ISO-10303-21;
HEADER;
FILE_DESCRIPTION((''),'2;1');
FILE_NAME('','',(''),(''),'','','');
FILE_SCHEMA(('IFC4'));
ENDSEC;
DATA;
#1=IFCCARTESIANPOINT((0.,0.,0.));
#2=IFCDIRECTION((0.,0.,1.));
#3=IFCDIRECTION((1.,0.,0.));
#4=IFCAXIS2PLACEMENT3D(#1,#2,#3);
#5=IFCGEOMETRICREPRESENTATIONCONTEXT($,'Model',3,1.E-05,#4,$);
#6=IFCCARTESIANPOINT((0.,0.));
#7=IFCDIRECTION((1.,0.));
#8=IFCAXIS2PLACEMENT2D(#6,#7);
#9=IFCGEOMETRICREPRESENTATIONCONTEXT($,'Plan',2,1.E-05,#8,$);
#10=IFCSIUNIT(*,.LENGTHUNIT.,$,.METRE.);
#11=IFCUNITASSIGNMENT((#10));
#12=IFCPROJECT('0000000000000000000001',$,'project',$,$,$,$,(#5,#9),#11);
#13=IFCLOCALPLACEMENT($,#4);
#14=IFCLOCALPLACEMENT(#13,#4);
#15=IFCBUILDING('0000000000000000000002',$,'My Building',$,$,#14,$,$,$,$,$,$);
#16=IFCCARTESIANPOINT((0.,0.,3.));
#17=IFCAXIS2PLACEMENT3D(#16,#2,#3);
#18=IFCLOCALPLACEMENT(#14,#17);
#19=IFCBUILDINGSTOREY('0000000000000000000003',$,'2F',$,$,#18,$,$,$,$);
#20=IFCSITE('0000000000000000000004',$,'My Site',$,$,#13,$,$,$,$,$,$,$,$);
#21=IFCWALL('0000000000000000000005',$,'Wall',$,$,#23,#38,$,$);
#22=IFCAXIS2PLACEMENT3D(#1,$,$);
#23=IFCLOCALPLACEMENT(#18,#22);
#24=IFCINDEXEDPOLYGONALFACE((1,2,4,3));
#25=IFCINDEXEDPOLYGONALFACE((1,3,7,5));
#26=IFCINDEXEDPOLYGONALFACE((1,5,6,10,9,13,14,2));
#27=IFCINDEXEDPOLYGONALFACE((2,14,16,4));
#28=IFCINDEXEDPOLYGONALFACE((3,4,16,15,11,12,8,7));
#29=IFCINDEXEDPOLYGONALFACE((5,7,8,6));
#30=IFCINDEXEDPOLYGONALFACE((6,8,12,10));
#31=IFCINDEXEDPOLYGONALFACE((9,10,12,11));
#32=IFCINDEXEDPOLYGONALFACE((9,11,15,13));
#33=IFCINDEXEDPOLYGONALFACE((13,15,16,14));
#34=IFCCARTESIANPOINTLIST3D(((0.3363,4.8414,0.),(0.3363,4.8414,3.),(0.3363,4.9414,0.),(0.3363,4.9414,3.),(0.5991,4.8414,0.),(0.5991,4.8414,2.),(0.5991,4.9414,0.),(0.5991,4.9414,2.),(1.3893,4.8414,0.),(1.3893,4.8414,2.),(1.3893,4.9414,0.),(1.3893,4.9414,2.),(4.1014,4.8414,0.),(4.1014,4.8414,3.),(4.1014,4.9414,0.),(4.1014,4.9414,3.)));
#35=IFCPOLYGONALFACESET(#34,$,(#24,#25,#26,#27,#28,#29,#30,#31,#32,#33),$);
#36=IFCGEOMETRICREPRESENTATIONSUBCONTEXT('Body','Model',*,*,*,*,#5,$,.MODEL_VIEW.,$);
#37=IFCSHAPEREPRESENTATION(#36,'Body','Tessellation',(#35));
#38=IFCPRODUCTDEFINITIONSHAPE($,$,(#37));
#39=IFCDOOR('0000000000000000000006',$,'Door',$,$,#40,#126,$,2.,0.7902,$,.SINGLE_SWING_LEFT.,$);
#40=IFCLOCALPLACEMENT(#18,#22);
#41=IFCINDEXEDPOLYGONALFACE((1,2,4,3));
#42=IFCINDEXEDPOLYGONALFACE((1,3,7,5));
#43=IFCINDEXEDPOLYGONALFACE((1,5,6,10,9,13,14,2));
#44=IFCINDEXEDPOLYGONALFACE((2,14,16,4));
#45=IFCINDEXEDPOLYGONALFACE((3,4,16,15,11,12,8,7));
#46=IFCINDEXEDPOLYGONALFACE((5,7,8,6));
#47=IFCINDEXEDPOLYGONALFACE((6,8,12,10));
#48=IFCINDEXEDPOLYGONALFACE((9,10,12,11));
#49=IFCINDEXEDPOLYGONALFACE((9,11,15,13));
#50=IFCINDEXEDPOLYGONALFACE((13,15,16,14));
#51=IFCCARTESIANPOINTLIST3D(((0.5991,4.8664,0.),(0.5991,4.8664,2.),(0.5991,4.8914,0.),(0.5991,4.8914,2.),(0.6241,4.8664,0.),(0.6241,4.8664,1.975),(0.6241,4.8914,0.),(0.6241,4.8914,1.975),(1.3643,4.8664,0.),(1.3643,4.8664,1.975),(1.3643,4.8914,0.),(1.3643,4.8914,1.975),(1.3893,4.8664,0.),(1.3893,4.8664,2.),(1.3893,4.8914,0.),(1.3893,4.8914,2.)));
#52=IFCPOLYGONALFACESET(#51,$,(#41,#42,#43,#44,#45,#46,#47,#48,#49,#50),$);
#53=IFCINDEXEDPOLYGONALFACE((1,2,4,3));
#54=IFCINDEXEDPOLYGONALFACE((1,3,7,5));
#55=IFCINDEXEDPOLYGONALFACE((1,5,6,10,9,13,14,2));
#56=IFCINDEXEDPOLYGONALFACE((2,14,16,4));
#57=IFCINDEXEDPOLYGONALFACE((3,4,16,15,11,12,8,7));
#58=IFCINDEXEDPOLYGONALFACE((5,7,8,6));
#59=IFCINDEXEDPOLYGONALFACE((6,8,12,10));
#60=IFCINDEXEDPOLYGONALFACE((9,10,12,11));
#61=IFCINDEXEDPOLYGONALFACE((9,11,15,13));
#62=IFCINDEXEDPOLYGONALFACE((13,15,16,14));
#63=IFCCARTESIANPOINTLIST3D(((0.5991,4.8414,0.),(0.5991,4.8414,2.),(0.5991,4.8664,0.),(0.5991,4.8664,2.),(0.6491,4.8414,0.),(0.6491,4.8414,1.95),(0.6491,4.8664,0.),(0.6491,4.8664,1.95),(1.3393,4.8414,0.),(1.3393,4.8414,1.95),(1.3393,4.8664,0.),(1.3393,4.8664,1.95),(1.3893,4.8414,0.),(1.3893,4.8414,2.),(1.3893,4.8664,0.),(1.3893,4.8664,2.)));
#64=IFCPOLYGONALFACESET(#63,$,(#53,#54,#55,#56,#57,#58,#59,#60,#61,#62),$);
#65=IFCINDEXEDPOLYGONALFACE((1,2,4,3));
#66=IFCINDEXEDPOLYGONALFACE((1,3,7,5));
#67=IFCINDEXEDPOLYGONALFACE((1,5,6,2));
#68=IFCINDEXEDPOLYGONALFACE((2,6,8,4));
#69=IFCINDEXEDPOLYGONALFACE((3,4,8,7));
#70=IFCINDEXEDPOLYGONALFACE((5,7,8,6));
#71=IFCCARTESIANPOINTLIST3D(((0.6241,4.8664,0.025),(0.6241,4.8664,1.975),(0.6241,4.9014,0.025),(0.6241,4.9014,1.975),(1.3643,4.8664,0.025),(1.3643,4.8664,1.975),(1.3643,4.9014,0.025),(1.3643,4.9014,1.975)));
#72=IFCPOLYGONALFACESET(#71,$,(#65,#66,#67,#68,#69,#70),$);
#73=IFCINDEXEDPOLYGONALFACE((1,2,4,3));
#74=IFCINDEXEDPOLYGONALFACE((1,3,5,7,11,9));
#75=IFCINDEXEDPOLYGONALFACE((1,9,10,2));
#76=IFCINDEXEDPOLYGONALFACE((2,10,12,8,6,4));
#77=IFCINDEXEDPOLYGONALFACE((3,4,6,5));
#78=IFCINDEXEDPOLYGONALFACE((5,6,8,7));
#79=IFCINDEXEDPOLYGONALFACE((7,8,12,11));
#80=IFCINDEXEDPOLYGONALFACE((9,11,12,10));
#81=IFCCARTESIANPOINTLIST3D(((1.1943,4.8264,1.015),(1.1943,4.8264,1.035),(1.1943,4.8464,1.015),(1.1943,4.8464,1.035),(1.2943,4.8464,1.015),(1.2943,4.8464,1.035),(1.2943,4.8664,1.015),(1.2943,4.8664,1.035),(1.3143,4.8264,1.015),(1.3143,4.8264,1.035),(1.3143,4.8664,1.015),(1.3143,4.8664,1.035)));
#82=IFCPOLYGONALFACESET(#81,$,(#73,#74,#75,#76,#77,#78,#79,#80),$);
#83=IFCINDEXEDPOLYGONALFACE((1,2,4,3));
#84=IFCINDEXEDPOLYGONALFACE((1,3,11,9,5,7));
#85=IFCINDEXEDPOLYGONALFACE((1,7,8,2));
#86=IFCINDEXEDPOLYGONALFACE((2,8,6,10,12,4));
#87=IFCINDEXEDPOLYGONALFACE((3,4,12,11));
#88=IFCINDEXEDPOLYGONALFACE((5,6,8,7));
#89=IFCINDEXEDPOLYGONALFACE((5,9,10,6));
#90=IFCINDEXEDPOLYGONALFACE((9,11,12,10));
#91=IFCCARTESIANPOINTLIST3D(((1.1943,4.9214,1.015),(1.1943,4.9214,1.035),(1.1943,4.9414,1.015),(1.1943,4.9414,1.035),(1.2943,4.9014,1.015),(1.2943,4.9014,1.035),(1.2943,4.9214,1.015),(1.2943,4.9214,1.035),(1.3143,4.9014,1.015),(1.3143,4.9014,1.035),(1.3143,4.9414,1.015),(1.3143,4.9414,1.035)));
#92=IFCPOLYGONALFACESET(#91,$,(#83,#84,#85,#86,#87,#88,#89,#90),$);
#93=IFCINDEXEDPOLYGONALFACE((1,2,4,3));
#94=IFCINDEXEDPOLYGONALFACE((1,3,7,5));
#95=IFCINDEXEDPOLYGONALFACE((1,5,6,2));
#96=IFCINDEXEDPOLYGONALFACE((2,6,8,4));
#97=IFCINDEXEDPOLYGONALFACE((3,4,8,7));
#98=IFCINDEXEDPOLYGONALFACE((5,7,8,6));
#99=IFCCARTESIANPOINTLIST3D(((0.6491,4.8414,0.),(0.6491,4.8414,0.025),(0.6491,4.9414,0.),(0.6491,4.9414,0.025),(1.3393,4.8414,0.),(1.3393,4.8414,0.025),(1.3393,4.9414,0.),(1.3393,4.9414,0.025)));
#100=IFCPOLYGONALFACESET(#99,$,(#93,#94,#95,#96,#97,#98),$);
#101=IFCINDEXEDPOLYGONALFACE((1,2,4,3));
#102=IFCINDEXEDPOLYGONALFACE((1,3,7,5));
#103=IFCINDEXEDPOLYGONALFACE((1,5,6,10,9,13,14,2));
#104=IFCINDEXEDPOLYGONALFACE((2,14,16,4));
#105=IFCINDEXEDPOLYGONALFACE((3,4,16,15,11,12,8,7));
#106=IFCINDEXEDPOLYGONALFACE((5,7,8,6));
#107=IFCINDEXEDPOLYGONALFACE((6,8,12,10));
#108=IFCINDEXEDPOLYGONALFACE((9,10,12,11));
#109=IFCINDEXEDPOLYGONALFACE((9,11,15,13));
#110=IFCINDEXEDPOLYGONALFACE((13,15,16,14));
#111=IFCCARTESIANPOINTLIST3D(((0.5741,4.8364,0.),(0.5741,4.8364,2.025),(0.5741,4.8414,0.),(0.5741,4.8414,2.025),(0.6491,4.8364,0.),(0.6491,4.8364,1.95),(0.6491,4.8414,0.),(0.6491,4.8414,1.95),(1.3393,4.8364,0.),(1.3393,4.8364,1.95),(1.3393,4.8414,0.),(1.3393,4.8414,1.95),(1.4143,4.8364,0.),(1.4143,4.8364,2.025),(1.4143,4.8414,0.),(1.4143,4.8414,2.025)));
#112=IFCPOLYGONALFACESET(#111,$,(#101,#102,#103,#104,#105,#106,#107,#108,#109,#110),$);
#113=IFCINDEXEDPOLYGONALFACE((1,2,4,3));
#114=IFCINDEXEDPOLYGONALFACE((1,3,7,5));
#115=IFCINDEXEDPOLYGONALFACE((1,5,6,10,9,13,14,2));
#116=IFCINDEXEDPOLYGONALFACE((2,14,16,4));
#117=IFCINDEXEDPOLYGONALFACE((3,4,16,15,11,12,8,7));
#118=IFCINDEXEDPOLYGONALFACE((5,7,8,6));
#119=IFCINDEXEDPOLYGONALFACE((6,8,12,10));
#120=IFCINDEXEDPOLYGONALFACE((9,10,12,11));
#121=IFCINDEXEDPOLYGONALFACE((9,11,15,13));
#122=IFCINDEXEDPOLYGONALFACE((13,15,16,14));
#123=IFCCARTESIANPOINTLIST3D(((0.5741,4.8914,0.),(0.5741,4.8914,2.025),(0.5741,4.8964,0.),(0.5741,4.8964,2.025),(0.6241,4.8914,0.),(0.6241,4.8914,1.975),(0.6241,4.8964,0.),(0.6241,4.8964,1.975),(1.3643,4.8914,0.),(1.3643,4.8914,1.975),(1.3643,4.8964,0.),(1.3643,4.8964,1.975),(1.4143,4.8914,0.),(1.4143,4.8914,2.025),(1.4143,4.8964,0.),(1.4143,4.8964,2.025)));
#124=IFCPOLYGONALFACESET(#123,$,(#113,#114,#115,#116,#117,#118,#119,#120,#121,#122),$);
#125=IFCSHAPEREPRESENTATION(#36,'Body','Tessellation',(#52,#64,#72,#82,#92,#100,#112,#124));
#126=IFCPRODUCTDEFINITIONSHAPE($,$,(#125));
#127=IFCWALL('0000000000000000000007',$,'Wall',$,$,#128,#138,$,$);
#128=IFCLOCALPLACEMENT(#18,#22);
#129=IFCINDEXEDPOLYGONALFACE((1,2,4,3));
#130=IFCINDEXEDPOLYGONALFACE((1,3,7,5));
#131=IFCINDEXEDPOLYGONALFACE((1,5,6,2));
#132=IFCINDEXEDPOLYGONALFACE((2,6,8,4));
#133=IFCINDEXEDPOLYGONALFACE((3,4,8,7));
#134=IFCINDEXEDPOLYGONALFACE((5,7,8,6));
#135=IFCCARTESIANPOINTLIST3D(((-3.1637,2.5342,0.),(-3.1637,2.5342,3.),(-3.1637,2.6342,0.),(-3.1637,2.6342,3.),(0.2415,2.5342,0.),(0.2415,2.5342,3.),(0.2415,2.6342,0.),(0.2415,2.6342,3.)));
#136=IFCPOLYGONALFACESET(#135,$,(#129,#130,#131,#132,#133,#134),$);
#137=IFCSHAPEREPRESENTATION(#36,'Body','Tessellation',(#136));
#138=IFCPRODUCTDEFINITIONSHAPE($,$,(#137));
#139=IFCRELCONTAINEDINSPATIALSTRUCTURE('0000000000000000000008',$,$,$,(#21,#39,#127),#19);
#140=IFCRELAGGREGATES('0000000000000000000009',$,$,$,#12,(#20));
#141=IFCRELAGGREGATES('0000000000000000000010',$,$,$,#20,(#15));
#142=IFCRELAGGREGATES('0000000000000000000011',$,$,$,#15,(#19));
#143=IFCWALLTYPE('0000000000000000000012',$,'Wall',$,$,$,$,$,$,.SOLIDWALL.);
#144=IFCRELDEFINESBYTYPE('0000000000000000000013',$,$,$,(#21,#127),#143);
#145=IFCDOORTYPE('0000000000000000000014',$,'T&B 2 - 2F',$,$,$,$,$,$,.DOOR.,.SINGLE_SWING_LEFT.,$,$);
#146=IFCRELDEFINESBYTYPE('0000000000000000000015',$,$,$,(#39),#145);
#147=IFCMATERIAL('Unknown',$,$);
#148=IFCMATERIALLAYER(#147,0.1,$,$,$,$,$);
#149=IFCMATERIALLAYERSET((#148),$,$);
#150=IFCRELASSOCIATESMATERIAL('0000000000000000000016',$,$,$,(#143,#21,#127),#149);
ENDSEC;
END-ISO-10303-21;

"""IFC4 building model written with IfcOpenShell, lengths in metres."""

from ifc_helpers import new_model, entity, si_unit, frame, origin_with_axes, origin_2d_with_axis, place, context, subcontext, project, spatial, line, indexed_curve, outline, extrude, shape, source, transform, mapped, material, layer, layer_set, layer_usage, type_object, type_shapes, element, fill, save


model = new_model("IFC4")

# Units and contexts
model_context = context("Model", 3, precision=1e-05, world=origin_with_axes())
plan_context = context("Plan", 2, precision=1e-05, world=origin_2d_with_axis())
body_context_1 = subcontext(model_context, "Body", "Model", "MODEL_VIEW")
body_context_2 = subcontext(plan_context, "Body", "Plan", "PLAN_VIEW")
ifc_project = project(units=[si_unit("LENGTHUNIT", "METRE")], contexts=[model_context, plan_context])

# Site, building, storey
site_placement = place(None, origin_with_axes())
site = spatial("IfcSite", under=ifc_project, at=site_placement, Name="My Site")
building_placement = place(site_placement, origin_with_axes())
building = spatial("IfcBuilding", under=site, at=building_placement, Name="My Building")
storey_placement = place(building_placement, frame((0.0, 0.0, 3.0), z_axis=(0.0, 0.0, 1.0), x_axis=(1.0, 0.0, 0.0)))
storey = spatial("IfcBuildingStorey", under=building, at=storey_placement, Name="2F")

# Shared definitions
ifc_material = material(Name="Unknown")

# Shared definitions
ifc_layer_1 = layer(ifc_material, 0.1)
ifc_layer_set_1 = layer_set([ifc_layer_1])
wall_type = type_object("IfcWallType", Name="Wall", PredefinedType="SOLIDWALL", material=ifc_layer_set_1)

# Wall, opening, door
ifc_layer_usage_1 = layer_usage(ifc_layer_set_1, "AXIS2", "POSITIVE", 0.0)
wall_1_placement = place(storey_placement, frame((0.3363, 4.8414, 0.0), z_axis=(0.0, 0.0, 1.0), x_axis=(1.0, 0.0, 0.0)))
wall_1 = element("IfcWall", 1, at=wall_1_placement, inside=storey, type_object=wall_type, material=ifc_layer_usage_1, Name="Wall", context=body_context_1, shape_type="SweptSolid", body=[
    extrude(outline(indexed_curve([(0.0, 0.0), (0.0, 0.1), (3.7651, 0.1), (3.7651, 0.0)], segments=[line(1, 2, 3, 4, 1)])), origin_with_axes(), (0.0, 0.0, 1.0), 3.0),
])
shared_shape_1 = source(origin_with_axes(), body_context_1, "Body", "SweptSolid", [
    extrude(outline(indexed_curve([(0.0, 0.0), (0.7902, 0.0), (0.7902, 2.0), (0.0, 2.0)], segments=[line(1, 2, 3, 4, 1)])), frame((0.0, -0.6, 0.0), z_axis=(0.0, -1.0, 0.0), x_axis=(1.0, 0.0, 0.0)), (0.0, 0.0, -1.0), 1.2),
])
opening_1_placement = place(wall_1_placement, frame((0.2628, 0.0, 0.0), z_axis=(0.0, 0.0, 1.0), x_axis=(1.0, 0.0, 0.0)))
opening_1 = element("IfcOpeningElement", 2, at=opening_1_placement, cuts=wall_1, PredefinedType="OPENING", context=body_context_1, shape_type="MappedRepresentation", body=[
    mapped(shared_shape_1, transform((0.0, 0.0, 0.0), x_axis=(1.0, 0.0, 0.0), y_axis=(0.0, 1.0, 0.0), z_axis=(0.0, 0.0, 1.0), scale=1.0)),
])
door_type_1 = type_object("IfcDoorType", Name="T&B 2 - 2F", OperationType="SINGLE_SWING_LEFT", PredefinedType="DOOR")
shared_shape_2 = source(origin_with_axes(), body_context_1, "Body", "SweptSolid", [
    extrude(outline(indexed_curve([(0.0, 0.0), (0.0, 2.0), (0.7902, 2.0), (0.7902, 0.0), (0.7652, 0.0), (0.7652, 1.975), (0.025, 1.975), (0.025, 0.0)], segments=[line(1, 2, 3, 4, 5, 6, 7, 8, 1)])), frame((0.0, 0.025, 0.0), z_axis=(0.0, -1.0, 0.0), x_axis=(1.0, 0.0, 0.0)), (0.0, 0.0, -1.0), 0.025),
    extrude(outline(indexed_curve([(0.0, 0.0), (0.0, 2.0), (0.7902, 2.0), (0.7902, 0.0), (0.7402, 0.0), (0.7402, 1.95), (0.05, 1.95), (0.05, 0.0)], segments=[line(1, 2, 3, 4, 5, 6, 7, 8, 1)])), frame((0.0, 0.0, 0.0), z_axis=(0.0, -1.0, 0.0), x_axis=(1.0, 0.0, 0.0)), (0.0, 0.0, -1.0), 0.025),
    extrude(outline(indexed_curve([(0.0, 0.0), (0.7402, 0.0), (0.7402, 0.035), (0.0, 0.035)], segments=[line(1, 2, 3, 4, 1)])), frame((0.025, 0.025, 0.025), z_axis=(0.0, 0.0, 1.0), x_axis=(1.0, 0.0, 0.0)), (0.0, 0.0, 1.0), 1.95),
    extrude(outline(indexed_curve([(0.0, 0.0), (0.0, -0.04), (-0.12, -0.04), (-0.12, -0.02), (-0.02, -0.02), (-0.02, 0.0)], segments=[line(1, 2, 3, 4, 5, 6, 1)])), frame((0.7152, 0.025, 1.015), z_axis=(0.0, 0.0, 1.0), x_axis=(1.0, 0.0, 0.0)), (0.0, 0.0, 1.0), 0.02),
    extrude(outline(indexed_curve([(0.0, 0.0), (0.0, 0.04), (-0.12, 0.04), (-0.12, 0.02), (-0.02, 0.02), (-0.02, 0.0)], segments=[line(1, 2, 3, 4, 5, 6, 1)])), frame((0.7152, 0.06, 1.015), z_axis=(0.0, 0.0, 1.0), x_axis=(1.0, 0.0, 0.0)), (0.0, 0.0, 1.0), 0.02),
    extrude(outline(indexed_curve([(0.0, 0.0), (0.6902, 0.0), (0.6902, 0.1), (0.0, 0.1)], segments=[line(1, 2, 3, 4, 1)])), frame((0.05, 0.0, 0.0), z_axis=(0.0, 0.0, 1.0), x_axis=(1.0, 0.0, 0.0)), (0.0, 0.0, 1.0), 0.025),
    extrude(outline(indexed_curve([(0.0, 0.0), (0.0, 2.025), (0.8402, 2.025), (0.8402, 0.0), (0.7652, 0.0), (0.7652, 1.95), (0.075, 1.95), (0.075, 0.0)], segments=[line(1, 2, 3, 4, 5, 6, 7, 8, 1)])), frame((-0.025, -0.005, 0.0), z_axis=(0.0, -1.0, 0.0), x_axis=(1.0, 0.0, 0.0)), (0.0, 0.0, -1.0), 0.005),
    extrude(outline(indexed_curve([(0.0, 0.0), (0.0, 2.025), (0.8402, 2.025), (0.8402, 0.0), (0.7902, 0.0), (0.7902, 1.975), (0.05, 1.975), (0.05, 0.0)], segments=[line(1, 2, 3, 4, 5, 6, 7, 8, 1)])), frame((-0.025, 0.05, 0.0), z_axis=(0.0, -1.0, 0.0), x_axis=(1.0, 0.0, 0.0)), (0.0, 0.0, -1.0), 0.005),
])
shared_shape_3 = source(origin_with_axes(), body_context_2, "Body", "Curve2D", [
    entity("IfcIndexedPolyCurve", entity("IfcCartesianPointList2D", [[0.0, 0.0], [0.0, 0.05], [0.025, 0.05], [0.025, 0.025], [0.05, 0.025], [0.05, 0.0]]), [entity("IfcLineIndex", [1, 2, 3, 4, 5, 6, 1])]),
    entity("IfcIndexedPolyCurve", entity("IfcCartesianPointList2D", [[0.7902, 0.0], [0.7902, 0.05], [0.7652, 0.05], [0.7652, 0.025], [0.7402, 0.025], [0.7402, 0.0]]), [entity("IfcLineIndex", [1, 2, 3, 4, 5, 6, 1])]),
    entity("IfcTrimmedCurve", entity("IfcEllipse", entity("IfcAxis2Placement2D", entity("IfcCartesianPoint", [0.06, 0.05]), entity("IfcDirection", [1.0, 0.0])), 0.7052, 0.7402), [entity("IfcCartesianPoint", [0.7652, 0.05])], [entity("IfcCartesianPoint", [0.06, 0.7902])], True, "CARTESIAN"),
    entity("IfcIndexedPolyCurve", entity("IfcCartesianPointList2D", [[0.025, 0.05], [0.06, 0.05], [0.06, 0.7902], [0.025, 0.7902]]), [entity("IfcLineIndex", [1, 2, 3, 4, 1])]),
])
type_shapes(door_type_1, [shared_shape_2, shared_shape_3])
door_1_placement = place(opening_1_placement, origin_with_axes())
door_1 = element("IfcDoor", 3, at=door_1_placement, inside=storey, type_object=door_type_1, Name="Door", OperationType="SINGLE_SWING_LEFT", OverallHeight=2.0, OverallWidth=0.7902, shapes=[
    shape(body_context_1, "Body", "MappedRepresentation", [mapped(shared_shape_2, transform((0.0, 0.0, 0.0), x_axis=(1.0, 0.0, 0.0), y_axis=(0.0, 1.0, 0.0), z_axis=(0.0, 0.0, 1.0), scale=1.0))]),
    shape(body_context_2, "Body", "MappedRepresentation", [mapped(shared_shape_3, transform((0.0, 0.0, 0.0), x_axis=(1.0, 0.0, 0.0), y_axis=(0.0, 1.0, 0.0), z_axis=(0.0, 0.0, 1.0), scale=1.0))]),
])
fill(opening_1, door_1)

# Wall
ifc_layer_usage_2 = layer_usage(ifc_layer_set_1, "AXIS2", "POSITIVE", 0.0)
wall_2_placement = place(storey_placement, frame((-3.1637, 2.5342, 0.0), z_axis=(0.0, 0.0, 1.0), x_axis=(1.0, 0.0, 0.0)))
element("IfcWall", 4, at=wall_2_placement, inside=storey, type_object=wall_type, material=ifc_layer_usage_2, Name="Wall", context=body_context_1, shape_type="SweptSolid", body=[
    extrude(outline(indexed_curve([(0.0, 0.0), (0.0, 0.1), (3.4052, 0.1), (3.4052, 0.0)], segments=[line(1, 2, 3, 4, 1)])), origin_with_axes(), (0.0, 0.0, 1.0), 3.0),
])

save(model, "model.ifc")
